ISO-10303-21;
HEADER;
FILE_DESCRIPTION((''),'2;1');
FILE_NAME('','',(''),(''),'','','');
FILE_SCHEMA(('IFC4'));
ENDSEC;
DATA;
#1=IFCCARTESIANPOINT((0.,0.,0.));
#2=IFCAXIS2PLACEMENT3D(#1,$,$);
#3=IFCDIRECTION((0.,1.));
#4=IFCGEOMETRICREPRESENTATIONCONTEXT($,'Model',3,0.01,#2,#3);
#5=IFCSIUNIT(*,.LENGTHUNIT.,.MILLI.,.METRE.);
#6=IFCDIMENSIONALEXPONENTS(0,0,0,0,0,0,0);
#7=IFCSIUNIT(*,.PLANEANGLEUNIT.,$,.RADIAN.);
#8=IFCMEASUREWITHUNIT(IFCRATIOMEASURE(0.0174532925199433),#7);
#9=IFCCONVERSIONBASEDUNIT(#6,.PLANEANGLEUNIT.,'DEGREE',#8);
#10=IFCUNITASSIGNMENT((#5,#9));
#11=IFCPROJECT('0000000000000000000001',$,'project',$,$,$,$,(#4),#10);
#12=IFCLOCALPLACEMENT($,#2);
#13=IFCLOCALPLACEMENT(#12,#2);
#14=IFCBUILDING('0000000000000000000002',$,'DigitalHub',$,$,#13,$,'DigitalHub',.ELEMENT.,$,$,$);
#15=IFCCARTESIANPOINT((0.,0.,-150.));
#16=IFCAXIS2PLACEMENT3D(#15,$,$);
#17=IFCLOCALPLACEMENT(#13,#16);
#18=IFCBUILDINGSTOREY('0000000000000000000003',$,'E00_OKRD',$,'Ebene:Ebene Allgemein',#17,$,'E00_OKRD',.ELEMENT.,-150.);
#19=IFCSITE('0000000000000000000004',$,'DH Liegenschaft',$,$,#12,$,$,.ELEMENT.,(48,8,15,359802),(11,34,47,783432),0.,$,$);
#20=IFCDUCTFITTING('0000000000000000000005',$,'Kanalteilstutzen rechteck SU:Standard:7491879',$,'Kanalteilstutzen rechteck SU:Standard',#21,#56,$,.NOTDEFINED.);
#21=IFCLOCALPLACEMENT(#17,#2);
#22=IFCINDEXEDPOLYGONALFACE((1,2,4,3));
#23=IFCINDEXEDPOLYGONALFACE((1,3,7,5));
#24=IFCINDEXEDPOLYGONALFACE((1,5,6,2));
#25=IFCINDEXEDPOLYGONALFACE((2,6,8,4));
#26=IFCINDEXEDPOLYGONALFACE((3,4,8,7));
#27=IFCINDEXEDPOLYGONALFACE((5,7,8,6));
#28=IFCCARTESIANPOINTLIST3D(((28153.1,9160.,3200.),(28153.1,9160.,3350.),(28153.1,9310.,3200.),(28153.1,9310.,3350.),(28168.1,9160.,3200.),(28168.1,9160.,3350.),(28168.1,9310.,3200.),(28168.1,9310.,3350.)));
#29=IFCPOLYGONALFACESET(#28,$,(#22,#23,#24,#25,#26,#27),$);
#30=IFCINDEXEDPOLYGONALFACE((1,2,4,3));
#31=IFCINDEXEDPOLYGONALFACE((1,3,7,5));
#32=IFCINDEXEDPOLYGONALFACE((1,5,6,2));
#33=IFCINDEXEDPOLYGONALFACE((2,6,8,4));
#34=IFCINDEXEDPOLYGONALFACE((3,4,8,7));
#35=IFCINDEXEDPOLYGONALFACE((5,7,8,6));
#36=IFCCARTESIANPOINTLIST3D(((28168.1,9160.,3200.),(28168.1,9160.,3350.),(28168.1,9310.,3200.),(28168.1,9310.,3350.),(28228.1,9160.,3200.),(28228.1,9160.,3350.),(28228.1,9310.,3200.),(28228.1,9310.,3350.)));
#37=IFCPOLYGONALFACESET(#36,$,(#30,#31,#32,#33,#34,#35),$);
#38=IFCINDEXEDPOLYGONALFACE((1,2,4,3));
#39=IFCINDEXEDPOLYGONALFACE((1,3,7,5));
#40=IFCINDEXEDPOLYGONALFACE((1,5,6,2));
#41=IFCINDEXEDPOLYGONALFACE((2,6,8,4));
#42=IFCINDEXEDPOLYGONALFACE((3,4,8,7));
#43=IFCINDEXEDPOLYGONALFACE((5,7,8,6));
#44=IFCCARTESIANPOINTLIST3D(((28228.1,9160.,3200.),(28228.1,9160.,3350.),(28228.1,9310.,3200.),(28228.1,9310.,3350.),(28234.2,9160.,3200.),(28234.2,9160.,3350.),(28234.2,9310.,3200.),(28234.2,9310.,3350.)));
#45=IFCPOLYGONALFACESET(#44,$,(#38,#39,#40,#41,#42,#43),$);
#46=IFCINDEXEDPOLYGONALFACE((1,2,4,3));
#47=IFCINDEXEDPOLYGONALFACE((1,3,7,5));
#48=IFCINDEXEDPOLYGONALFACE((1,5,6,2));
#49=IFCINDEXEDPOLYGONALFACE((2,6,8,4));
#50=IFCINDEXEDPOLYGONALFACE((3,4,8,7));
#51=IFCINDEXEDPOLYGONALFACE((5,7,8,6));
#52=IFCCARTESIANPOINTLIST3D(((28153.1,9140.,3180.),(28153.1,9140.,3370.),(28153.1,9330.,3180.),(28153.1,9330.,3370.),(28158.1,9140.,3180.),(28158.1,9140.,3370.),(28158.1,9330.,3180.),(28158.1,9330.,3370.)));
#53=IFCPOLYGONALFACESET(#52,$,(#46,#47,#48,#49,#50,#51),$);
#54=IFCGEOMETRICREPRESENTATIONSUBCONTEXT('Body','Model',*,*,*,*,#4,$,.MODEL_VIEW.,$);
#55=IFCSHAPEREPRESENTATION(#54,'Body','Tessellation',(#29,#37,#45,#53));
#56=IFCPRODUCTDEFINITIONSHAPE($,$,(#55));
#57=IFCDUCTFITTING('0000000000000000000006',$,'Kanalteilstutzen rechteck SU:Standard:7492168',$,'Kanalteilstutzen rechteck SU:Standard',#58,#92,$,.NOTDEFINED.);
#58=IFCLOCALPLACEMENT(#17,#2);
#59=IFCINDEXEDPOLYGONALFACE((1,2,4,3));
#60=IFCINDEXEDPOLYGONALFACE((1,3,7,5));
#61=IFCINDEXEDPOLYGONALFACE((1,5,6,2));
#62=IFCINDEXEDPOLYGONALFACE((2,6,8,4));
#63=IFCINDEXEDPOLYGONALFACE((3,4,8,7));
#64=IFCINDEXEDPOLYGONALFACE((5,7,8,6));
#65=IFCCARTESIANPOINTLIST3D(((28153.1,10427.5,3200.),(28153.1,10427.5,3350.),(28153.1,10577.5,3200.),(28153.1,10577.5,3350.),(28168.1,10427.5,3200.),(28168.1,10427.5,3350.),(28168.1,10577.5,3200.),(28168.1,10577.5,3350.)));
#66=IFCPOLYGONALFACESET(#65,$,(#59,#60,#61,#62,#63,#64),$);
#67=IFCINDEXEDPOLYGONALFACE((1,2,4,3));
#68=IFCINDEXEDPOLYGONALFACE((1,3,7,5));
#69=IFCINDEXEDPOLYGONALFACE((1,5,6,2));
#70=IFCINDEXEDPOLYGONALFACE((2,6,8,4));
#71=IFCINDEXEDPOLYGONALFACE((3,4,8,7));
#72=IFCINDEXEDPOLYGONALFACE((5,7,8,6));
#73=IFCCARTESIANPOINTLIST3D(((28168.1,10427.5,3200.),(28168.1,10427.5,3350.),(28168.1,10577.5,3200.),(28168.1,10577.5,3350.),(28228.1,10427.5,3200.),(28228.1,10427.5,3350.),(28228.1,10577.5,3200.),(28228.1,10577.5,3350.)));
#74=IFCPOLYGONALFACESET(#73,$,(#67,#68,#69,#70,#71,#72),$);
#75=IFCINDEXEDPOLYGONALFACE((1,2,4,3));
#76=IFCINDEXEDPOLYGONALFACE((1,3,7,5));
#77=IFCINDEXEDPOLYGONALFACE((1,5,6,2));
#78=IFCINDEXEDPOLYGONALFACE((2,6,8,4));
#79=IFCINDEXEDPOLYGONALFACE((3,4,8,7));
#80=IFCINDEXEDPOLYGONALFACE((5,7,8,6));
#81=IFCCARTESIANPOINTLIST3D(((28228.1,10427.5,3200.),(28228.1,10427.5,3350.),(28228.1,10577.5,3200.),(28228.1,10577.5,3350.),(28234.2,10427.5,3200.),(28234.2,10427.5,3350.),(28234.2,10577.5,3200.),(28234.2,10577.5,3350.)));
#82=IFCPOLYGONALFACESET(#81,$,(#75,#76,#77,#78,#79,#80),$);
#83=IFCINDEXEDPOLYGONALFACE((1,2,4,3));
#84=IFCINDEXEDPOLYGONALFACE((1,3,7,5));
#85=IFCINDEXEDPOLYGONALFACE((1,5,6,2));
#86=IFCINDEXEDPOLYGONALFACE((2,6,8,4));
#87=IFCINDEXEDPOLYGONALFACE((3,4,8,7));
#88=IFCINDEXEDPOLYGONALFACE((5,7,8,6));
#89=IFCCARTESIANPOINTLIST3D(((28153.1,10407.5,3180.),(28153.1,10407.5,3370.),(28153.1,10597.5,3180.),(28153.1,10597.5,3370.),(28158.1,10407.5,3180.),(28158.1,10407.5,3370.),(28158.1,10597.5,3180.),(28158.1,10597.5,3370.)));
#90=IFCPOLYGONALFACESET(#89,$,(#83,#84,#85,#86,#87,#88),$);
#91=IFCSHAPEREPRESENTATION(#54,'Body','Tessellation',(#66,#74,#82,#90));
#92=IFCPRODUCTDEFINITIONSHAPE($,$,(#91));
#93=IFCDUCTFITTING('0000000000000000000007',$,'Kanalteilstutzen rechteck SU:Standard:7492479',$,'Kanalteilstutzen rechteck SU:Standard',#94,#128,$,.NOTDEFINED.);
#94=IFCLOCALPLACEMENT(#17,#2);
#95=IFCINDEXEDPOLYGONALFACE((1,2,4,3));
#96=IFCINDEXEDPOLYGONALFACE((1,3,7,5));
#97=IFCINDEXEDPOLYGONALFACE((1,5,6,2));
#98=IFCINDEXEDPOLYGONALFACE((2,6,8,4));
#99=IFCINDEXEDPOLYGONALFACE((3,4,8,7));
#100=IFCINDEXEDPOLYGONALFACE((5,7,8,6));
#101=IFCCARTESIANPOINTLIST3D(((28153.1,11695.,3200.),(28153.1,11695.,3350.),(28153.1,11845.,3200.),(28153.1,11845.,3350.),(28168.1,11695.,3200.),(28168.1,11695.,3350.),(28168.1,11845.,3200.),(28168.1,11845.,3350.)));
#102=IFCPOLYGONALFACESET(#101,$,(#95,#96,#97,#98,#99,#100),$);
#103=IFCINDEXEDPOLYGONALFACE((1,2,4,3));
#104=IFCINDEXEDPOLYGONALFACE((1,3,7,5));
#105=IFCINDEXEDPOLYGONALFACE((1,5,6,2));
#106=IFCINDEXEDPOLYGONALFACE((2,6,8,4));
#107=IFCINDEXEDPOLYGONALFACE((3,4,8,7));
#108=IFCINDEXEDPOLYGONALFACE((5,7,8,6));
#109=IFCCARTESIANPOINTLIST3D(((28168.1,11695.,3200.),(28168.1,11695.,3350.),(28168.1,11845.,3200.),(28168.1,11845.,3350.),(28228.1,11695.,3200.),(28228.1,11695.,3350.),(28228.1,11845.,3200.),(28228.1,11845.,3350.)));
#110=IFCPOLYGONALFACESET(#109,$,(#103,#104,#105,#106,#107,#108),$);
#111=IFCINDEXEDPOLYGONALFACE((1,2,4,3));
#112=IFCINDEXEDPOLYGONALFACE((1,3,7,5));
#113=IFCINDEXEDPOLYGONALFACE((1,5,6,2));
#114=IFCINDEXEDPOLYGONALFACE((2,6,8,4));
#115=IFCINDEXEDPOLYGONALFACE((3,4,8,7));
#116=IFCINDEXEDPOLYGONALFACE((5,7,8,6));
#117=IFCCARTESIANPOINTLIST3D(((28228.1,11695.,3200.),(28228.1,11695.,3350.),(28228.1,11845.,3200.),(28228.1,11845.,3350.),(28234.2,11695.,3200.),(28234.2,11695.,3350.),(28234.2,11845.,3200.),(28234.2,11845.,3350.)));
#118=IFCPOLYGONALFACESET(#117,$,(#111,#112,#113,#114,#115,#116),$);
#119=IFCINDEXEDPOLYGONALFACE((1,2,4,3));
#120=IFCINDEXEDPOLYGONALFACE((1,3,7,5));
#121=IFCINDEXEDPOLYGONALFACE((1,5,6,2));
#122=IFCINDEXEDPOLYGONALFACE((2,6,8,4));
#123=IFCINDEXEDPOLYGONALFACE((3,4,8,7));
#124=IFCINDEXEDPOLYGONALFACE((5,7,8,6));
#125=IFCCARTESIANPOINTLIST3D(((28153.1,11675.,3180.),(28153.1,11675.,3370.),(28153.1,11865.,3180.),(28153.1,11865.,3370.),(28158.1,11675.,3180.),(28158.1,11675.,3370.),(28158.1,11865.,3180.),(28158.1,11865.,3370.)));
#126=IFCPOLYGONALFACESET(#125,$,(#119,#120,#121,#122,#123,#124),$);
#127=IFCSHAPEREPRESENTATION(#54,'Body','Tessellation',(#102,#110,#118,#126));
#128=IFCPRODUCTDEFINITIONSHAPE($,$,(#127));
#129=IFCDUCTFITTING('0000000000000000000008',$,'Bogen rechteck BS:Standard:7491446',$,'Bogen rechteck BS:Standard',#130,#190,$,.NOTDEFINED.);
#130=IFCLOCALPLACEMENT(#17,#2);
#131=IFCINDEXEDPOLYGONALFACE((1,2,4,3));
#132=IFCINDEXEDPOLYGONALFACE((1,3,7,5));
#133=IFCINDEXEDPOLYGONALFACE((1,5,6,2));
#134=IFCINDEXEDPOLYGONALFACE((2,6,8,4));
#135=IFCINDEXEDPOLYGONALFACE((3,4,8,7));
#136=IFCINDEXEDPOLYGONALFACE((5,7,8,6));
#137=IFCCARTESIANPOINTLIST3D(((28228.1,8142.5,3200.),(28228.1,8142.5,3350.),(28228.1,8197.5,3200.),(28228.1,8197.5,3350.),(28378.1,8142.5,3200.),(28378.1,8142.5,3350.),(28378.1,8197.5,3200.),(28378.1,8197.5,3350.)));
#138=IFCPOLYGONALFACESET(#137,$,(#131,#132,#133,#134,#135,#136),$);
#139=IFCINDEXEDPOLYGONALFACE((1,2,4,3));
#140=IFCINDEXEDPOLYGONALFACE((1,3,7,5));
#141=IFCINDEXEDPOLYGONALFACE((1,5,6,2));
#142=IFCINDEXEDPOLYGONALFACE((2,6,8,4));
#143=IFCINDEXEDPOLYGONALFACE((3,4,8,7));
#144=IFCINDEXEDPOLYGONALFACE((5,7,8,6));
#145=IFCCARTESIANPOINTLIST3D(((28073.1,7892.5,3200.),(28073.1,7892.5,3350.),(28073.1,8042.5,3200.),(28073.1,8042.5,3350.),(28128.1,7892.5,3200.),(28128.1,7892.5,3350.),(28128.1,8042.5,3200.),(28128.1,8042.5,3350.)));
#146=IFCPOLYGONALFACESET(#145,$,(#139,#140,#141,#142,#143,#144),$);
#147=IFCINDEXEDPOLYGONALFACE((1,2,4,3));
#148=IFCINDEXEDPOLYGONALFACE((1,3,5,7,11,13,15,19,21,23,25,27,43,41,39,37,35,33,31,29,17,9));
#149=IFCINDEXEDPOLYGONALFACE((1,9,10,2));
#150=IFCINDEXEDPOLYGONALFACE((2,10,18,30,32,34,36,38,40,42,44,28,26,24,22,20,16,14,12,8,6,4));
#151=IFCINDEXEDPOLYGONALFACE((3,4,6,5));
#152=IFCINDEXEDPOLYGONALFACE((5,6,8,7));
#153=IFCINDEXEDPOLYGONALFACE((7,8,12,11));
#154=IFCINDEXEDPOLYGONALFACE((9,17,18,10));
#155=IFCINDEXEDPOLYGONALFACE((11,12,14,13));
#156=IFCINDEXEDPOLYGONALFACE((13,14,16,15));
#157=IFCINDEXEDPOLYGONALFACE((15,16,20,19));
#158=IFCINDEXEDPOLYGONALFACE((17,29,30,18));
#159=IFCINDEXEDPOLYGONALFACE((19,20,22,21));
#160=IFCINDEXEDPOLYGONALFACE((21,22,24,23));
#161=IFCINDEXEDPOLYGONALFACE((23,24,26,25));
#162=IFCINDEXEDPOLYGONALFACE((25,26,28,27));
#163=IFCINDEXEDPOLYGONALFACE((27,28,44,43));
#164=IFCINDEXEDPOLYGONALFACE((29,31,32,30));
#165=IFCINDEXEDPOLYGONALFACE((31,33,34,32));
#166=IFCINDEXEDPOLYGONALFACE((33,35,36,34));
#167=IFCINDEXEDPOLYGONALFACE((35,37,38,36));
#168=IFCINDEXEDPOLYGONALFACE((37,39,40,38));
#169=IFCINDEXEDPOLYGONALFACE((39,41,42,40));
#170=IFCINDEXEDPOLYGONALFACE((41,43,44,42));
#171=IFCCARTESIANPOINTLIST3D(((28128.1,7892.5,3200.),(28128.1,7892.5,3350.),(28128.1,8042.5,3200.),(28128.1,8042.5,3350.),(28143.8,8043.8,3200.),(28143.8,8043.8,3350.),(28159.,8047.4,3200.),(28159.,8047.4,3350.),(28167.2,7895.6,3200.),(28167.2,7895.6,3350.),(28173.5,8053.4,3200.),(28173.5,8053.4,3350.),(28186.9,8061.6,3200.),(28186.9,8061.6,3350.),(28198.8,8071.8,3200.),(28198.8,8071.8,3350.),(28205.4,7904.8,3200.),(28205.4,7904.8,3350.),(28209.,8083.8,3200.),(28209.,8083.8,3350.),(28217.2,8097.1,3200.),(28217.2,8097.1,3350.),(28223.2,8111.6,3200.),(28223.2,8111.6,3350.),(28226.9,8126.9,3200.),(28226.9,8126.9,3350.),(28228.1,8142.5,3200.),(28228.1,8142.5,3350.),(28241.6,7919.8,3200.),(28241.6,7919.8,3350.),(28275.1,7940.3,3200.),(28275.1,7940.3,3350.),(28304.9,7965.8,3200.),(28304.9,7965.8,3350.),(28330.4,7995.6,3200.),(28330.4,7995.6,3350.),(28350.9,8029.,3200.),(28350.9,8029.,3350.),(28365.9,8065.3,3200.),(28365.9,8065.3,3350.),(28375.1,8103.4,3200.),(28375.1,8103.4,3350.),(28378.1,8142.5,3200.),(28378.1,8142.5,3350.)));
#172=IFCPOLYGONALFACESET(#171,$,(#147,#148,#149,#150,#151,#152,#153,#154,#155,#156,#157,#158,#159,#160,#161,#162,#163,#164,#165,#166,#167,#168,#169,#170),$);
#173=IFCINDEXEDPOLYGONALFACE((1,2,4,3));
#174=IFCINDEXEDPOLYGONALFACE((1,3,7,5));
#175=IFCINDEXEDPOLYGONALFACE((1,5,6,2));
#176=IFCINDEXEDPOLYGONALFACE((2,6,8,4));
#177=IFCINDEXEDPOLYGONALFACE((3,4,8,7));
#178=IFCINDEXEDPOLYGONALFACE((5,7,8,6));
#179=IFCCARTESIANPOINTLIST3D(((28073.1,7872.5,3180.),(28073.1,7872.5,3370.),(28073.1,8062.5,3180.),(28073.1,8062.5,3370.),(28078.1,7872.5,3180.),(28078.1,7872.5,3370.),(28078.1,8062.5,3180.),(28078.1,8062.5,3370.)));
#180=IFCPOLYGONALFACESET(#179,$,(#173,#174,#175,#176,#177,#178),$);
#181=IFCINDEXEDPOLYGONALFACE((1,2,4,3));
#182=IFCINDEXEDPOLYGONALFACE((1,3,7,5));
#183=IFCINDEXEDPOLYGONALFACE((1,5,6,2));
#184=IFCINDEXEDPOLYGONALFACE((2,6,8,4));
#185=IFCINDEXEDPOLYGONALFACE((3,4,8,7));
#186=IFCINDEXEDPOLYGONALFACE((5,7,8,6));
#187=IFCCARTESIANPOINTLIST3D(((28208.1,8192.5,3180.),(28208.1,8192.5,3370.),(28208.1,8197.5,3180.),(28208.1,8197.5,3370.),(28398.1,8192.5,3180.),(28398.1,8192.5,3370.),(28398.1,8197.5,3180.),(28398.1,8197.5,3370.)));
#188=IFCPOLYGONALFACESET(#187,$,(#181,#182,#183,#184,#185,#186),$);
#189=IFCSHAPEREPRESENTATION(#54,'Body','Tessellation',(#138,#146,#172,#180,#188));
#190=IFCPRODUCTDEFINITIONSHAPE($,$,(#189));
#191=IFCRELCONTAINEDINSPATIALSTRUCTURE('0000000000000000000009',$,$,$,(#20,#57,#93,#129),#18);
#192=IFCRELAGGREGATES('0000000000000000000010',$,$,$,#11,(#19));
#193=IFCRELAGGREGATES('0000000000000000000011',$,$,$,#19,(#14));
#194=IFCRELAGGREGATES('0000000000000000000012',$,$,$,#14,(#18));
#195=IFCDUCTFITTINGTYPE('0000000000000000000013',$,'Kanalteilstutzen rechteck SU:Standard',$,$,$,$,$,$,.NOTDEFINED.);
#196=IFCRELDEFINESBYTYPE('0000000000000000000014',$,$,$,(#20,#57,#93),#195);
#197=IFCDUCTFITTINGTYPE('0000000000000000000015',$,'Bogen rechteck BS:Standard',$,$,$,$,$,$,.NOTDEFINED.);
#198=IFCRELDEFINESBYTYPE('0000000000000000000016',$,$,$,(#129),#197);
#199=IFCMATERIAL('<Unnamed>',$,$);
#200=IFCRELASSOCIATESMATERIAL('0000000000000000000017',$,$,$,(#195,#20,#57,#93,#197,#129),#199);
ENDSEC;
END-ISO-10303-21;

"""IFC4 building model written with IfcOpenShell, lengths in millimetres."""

from ifc_helpers import new_model, entity, si_unit, converted_unit, direction, frame, origin, place, context, subcontext, project, spatial, indexed_curve, outline, extrude, source, transform, mapped, material, type_object, type_shapes, element, save


model = new_model("IFC4")

# Units and contexts
model_context = context("Model", 3, precision=0.01, world=origin(), true_north=direction((0.0, 1.0)))
body_context = subcontext(model_context, "Body", "Model", "MODEL_VIEW")
ifc_project = project(units=[si_unit("LENGTHUNIT", "METRE", prefix="MILLI"), converted_unit("PLANEANGLEUNIT", "DEGREE", entity("IfcRatioMeasure", 0.0174532925199433), si_unit("PLANEANGLEUNIT", "RADIAN"), dimensions=[0, 0, 0, 0, 0, 0, 0])], contexts=[model_context])

# Site, building, storey
site_placement = place(None, origin())
site = spatial("IfcSite", under=ifc_project, at=site_placement, Name="DH Liegenschaft", CompositionType="ELEMENT", RefLatitude=(48, 8, 15, 359802), RefLongitude=(11, 34, 47, 783432), RefElevation=0.0)
building_placement = place(site_placement, origin())
building = spatial("IfcBuilding", under=site, at=building_placement, Name="DigitalHub", LongName="DigitalHub", CompositionType="ELEMENT")
storey_placement = place(building_placement, frame((0.0, 0.0, -150.0)))
storey = spatial("IfcBuildingStorey", under=building, at=storey_placement, Name="E00_OKRD", ObjectType="Ebene:Ebene Allgemein", LongName="E00_OKRD", CompositionType="ELEMENT", Elevation=-150.0)

# Shared definitions
ifc_material_1 = material(Name="<Unnamed>")

# Duct fittings
duct_fitting_type_1 = type_object("IfcDuctFittingType", Name="Kanalteilstutzen rechteck SU:Standard", PredefinedType="NOTDEFINED", material=ifc_material_1)
shared_shape_1 = source(origin(), body_context, "Body", "SweptSolid", [
    extrude(outline(indexed_curve([(-75.0, -7.5), (75.0, -7.5), (75.0, 7.5), (-75.0, 7.5), (-75.0, -7.5)], self_intersect=False)), frame((67.5, 0.0, -75.0), z_axis=(0.0, 0.0, 1.0), x_axis=(0.0, -1.0, 0.0)), (0.0, 0.0, 1.0), 150.0),
    extrude(outline(indexed_curve([(-75.0, -30.0), (75.0, -30.0), (75.0, 30.0), (-75.0, 30.0), (-75.0, -30.0)], self_intersect=False)), frame((30.0, 0.0, -75.0), z_axis=(0.0, 0.0, 1.0), x_axis=(0.0, -1.0, 0.0)), (0.0, 0.0, 1.0), 150.0),
    extrude(outline(indexed_curve([(-75.0, -3.0), (75.0, -3.0), (75.0, 3.0), (-75.0, 3.0), (-75.0, -3.0)], self_intersect=False)), frame((-3.0, 0.0, -75.0), z_axis=(0.0, 0.0, 1.0), x_axis=(0.0, -1.0, 0.0)), (0.0, 0.0, 1.0), 150.0),
    extrude(outline(indexed_curve([(-95.0, -2.5), (95.0, -2.5), (95.0, 2.5), (-95.0, 2.5), (-95.0, -2.5)], self_intersect=False)), frame((72.5, 0.0, -95.0), z_axis=(0.0, 0.0, 1.0), x_axis=(0.0, -1.0, 0.0)), (0.0, 0.0, 1.0), 190.0),
])
type_shapes(duct_fitting_type_1, [shared_shape_1])
for number, where, z_axis, x_axis, name in (
    (1, (28228.1, 9235.0, 3275.0), (0.0, 0.0, -1.0), (-1.0, 0.0, 0.0), "Kanalteilstutzen rechteck SU:Standard:7491879"),
    (2, (28228.1, 10502.5, 3275.0), (0.0, 0.0, -1.0), (-1.0, 0.0, 0.0), "Kanalteilstutzen rechteck SU:Standard:7492168"),
    (3, (28228.1, 11770.0, 3275.0), (0.0, 0.0, -1.0), (-1.0, 0.0, 0.0), "Kanalteilstutzen rechteck SU:Standard:7492479"),
):
    element("IfcDuctFitting", number, at=place(storey_placement, frame(where, z_axis=z_axis, x_axis=x_axis)), inside=storey, type_object=duct_fitting_type_1, material=ifc_material_1, Name=name, ObjectType="Kanalteilstutzen rechteck SU:Standard", PredefinedType="NOTDEFINED", context=body_context, shape_type="MappedRepresentation", body=[
        mapped(shared_shape_1, transform((0.0, 0.0, 0.0), scale=1.0)),
    ])
duct_fitting_type_2 = type_object("IfcDuctFittingType", Name="Bogen rechteck BS:Standard", PredefinedType="NOTDEFINED", material=ifc_material_1)
shared_shape_2 = source(origin(), body_context, "Body", "SweptSolid", [
    extrude(outline(indexed_curve([(-27.5, -75.0), (27.5, -75.0), (27.5, 75.0), (-27.5, 75.0), (-27.5, -75.0)], self_intersect=False)), frame((0.0, 202.5, -75.0), z_axis=(0.0, 0.0, 1.0), x_axis=(0.0, 1.0, 0.0)), (0.0, 0.0, 1.0), 150.0),
    extrude(outline(indexed_curve([(-75.0, -27.5), (75.0, -27.5), (75.0, 27.5), (-75.0, 27.5), (-75.0, -27.5)], self_intersect=False)), frame((-202.5, 0.0, -75.0), z_axis=(0.0, 0.0, 1.0), x_axis=(0.0, -1.0, 0.0)), (0.0, 0.0, 1.0), 150.0),
    extrude(outline(indexed_curve([(-162.5, -87.5), (-12.5, -87.5), (-11.3, -71.9), (-7.6, -56.6), (-1.6, -42.1), (6.6, -28.7), (16.8, -16.8), (28.7, -6.6), (42.1, 1.6), (56.6, 7.6), (71.9, 11.3), (87.5, 12.5), (87.5, 162.5), (48.4, 159.4), (10.2, 150.3), (-26.0, 135.3), (-59.4, 114.8), (-89.3, 89.3), (-114.8, 59.4), (-135.3, 26.0), (-150.3, -10.2), (-159.4, -48.4), (-162.5, -87.5)], self_intersect=False)), frame((-87.5, 87.5, -75.0), z_axis=(0.0, 0.0, 1.0), x_axis=(-1.0, 0.0, 0.0)), (0.0, 0.0, 1.0), 150.0),
    extrude(outline(indexed_curve([(-2.5, -95.0), (2.5, -95.0), (2.5, 95.0), (-2.5, 95.0), (-2.5, -95.0)], self_intersect=False)), frame((-227.5, 0.0, -95.0)), (0.0, 0.0, 1.0), 190.0),
    extrude(outline(indexed_curve([(-2.5, -95.0), (2.5, -95.0), (2.5, 95.0), (-2.5, 95.0), (-2.5, -95.0)], self_intersect=False)), frame((0.0, 227.5, -95.0), z_axis=(0.0, 0.0, 1.0), x_axis=(0.0, 1.0, 0.0)), (0.0, 0.0, 1.0), 190.0),
])
type_shapes(duct_fitting_type_2, [shared_shape_2])
duct_fitting_1_placement = place(storey_placement, frame((28303.1, 7967.5, 3275.0)))
element("IfcDuctFitting", 4, at=duct_fitting_1_placement, inside=storey, type_object=duct_fitting_type_2, material=ifc_material_1, Name="Bogen rechteck BS:Standard:7491446", ObjectType="Bogen rechteck BS:Standard", PredefinedType="NOTDEFINED", context=body_context, shape_type="MappedRepresentation", body=[
    mapped(shared_shape_2, transform((0.0, 0.0, 0.0), scale=1.0)),
])

save(model, "model.ifc")
